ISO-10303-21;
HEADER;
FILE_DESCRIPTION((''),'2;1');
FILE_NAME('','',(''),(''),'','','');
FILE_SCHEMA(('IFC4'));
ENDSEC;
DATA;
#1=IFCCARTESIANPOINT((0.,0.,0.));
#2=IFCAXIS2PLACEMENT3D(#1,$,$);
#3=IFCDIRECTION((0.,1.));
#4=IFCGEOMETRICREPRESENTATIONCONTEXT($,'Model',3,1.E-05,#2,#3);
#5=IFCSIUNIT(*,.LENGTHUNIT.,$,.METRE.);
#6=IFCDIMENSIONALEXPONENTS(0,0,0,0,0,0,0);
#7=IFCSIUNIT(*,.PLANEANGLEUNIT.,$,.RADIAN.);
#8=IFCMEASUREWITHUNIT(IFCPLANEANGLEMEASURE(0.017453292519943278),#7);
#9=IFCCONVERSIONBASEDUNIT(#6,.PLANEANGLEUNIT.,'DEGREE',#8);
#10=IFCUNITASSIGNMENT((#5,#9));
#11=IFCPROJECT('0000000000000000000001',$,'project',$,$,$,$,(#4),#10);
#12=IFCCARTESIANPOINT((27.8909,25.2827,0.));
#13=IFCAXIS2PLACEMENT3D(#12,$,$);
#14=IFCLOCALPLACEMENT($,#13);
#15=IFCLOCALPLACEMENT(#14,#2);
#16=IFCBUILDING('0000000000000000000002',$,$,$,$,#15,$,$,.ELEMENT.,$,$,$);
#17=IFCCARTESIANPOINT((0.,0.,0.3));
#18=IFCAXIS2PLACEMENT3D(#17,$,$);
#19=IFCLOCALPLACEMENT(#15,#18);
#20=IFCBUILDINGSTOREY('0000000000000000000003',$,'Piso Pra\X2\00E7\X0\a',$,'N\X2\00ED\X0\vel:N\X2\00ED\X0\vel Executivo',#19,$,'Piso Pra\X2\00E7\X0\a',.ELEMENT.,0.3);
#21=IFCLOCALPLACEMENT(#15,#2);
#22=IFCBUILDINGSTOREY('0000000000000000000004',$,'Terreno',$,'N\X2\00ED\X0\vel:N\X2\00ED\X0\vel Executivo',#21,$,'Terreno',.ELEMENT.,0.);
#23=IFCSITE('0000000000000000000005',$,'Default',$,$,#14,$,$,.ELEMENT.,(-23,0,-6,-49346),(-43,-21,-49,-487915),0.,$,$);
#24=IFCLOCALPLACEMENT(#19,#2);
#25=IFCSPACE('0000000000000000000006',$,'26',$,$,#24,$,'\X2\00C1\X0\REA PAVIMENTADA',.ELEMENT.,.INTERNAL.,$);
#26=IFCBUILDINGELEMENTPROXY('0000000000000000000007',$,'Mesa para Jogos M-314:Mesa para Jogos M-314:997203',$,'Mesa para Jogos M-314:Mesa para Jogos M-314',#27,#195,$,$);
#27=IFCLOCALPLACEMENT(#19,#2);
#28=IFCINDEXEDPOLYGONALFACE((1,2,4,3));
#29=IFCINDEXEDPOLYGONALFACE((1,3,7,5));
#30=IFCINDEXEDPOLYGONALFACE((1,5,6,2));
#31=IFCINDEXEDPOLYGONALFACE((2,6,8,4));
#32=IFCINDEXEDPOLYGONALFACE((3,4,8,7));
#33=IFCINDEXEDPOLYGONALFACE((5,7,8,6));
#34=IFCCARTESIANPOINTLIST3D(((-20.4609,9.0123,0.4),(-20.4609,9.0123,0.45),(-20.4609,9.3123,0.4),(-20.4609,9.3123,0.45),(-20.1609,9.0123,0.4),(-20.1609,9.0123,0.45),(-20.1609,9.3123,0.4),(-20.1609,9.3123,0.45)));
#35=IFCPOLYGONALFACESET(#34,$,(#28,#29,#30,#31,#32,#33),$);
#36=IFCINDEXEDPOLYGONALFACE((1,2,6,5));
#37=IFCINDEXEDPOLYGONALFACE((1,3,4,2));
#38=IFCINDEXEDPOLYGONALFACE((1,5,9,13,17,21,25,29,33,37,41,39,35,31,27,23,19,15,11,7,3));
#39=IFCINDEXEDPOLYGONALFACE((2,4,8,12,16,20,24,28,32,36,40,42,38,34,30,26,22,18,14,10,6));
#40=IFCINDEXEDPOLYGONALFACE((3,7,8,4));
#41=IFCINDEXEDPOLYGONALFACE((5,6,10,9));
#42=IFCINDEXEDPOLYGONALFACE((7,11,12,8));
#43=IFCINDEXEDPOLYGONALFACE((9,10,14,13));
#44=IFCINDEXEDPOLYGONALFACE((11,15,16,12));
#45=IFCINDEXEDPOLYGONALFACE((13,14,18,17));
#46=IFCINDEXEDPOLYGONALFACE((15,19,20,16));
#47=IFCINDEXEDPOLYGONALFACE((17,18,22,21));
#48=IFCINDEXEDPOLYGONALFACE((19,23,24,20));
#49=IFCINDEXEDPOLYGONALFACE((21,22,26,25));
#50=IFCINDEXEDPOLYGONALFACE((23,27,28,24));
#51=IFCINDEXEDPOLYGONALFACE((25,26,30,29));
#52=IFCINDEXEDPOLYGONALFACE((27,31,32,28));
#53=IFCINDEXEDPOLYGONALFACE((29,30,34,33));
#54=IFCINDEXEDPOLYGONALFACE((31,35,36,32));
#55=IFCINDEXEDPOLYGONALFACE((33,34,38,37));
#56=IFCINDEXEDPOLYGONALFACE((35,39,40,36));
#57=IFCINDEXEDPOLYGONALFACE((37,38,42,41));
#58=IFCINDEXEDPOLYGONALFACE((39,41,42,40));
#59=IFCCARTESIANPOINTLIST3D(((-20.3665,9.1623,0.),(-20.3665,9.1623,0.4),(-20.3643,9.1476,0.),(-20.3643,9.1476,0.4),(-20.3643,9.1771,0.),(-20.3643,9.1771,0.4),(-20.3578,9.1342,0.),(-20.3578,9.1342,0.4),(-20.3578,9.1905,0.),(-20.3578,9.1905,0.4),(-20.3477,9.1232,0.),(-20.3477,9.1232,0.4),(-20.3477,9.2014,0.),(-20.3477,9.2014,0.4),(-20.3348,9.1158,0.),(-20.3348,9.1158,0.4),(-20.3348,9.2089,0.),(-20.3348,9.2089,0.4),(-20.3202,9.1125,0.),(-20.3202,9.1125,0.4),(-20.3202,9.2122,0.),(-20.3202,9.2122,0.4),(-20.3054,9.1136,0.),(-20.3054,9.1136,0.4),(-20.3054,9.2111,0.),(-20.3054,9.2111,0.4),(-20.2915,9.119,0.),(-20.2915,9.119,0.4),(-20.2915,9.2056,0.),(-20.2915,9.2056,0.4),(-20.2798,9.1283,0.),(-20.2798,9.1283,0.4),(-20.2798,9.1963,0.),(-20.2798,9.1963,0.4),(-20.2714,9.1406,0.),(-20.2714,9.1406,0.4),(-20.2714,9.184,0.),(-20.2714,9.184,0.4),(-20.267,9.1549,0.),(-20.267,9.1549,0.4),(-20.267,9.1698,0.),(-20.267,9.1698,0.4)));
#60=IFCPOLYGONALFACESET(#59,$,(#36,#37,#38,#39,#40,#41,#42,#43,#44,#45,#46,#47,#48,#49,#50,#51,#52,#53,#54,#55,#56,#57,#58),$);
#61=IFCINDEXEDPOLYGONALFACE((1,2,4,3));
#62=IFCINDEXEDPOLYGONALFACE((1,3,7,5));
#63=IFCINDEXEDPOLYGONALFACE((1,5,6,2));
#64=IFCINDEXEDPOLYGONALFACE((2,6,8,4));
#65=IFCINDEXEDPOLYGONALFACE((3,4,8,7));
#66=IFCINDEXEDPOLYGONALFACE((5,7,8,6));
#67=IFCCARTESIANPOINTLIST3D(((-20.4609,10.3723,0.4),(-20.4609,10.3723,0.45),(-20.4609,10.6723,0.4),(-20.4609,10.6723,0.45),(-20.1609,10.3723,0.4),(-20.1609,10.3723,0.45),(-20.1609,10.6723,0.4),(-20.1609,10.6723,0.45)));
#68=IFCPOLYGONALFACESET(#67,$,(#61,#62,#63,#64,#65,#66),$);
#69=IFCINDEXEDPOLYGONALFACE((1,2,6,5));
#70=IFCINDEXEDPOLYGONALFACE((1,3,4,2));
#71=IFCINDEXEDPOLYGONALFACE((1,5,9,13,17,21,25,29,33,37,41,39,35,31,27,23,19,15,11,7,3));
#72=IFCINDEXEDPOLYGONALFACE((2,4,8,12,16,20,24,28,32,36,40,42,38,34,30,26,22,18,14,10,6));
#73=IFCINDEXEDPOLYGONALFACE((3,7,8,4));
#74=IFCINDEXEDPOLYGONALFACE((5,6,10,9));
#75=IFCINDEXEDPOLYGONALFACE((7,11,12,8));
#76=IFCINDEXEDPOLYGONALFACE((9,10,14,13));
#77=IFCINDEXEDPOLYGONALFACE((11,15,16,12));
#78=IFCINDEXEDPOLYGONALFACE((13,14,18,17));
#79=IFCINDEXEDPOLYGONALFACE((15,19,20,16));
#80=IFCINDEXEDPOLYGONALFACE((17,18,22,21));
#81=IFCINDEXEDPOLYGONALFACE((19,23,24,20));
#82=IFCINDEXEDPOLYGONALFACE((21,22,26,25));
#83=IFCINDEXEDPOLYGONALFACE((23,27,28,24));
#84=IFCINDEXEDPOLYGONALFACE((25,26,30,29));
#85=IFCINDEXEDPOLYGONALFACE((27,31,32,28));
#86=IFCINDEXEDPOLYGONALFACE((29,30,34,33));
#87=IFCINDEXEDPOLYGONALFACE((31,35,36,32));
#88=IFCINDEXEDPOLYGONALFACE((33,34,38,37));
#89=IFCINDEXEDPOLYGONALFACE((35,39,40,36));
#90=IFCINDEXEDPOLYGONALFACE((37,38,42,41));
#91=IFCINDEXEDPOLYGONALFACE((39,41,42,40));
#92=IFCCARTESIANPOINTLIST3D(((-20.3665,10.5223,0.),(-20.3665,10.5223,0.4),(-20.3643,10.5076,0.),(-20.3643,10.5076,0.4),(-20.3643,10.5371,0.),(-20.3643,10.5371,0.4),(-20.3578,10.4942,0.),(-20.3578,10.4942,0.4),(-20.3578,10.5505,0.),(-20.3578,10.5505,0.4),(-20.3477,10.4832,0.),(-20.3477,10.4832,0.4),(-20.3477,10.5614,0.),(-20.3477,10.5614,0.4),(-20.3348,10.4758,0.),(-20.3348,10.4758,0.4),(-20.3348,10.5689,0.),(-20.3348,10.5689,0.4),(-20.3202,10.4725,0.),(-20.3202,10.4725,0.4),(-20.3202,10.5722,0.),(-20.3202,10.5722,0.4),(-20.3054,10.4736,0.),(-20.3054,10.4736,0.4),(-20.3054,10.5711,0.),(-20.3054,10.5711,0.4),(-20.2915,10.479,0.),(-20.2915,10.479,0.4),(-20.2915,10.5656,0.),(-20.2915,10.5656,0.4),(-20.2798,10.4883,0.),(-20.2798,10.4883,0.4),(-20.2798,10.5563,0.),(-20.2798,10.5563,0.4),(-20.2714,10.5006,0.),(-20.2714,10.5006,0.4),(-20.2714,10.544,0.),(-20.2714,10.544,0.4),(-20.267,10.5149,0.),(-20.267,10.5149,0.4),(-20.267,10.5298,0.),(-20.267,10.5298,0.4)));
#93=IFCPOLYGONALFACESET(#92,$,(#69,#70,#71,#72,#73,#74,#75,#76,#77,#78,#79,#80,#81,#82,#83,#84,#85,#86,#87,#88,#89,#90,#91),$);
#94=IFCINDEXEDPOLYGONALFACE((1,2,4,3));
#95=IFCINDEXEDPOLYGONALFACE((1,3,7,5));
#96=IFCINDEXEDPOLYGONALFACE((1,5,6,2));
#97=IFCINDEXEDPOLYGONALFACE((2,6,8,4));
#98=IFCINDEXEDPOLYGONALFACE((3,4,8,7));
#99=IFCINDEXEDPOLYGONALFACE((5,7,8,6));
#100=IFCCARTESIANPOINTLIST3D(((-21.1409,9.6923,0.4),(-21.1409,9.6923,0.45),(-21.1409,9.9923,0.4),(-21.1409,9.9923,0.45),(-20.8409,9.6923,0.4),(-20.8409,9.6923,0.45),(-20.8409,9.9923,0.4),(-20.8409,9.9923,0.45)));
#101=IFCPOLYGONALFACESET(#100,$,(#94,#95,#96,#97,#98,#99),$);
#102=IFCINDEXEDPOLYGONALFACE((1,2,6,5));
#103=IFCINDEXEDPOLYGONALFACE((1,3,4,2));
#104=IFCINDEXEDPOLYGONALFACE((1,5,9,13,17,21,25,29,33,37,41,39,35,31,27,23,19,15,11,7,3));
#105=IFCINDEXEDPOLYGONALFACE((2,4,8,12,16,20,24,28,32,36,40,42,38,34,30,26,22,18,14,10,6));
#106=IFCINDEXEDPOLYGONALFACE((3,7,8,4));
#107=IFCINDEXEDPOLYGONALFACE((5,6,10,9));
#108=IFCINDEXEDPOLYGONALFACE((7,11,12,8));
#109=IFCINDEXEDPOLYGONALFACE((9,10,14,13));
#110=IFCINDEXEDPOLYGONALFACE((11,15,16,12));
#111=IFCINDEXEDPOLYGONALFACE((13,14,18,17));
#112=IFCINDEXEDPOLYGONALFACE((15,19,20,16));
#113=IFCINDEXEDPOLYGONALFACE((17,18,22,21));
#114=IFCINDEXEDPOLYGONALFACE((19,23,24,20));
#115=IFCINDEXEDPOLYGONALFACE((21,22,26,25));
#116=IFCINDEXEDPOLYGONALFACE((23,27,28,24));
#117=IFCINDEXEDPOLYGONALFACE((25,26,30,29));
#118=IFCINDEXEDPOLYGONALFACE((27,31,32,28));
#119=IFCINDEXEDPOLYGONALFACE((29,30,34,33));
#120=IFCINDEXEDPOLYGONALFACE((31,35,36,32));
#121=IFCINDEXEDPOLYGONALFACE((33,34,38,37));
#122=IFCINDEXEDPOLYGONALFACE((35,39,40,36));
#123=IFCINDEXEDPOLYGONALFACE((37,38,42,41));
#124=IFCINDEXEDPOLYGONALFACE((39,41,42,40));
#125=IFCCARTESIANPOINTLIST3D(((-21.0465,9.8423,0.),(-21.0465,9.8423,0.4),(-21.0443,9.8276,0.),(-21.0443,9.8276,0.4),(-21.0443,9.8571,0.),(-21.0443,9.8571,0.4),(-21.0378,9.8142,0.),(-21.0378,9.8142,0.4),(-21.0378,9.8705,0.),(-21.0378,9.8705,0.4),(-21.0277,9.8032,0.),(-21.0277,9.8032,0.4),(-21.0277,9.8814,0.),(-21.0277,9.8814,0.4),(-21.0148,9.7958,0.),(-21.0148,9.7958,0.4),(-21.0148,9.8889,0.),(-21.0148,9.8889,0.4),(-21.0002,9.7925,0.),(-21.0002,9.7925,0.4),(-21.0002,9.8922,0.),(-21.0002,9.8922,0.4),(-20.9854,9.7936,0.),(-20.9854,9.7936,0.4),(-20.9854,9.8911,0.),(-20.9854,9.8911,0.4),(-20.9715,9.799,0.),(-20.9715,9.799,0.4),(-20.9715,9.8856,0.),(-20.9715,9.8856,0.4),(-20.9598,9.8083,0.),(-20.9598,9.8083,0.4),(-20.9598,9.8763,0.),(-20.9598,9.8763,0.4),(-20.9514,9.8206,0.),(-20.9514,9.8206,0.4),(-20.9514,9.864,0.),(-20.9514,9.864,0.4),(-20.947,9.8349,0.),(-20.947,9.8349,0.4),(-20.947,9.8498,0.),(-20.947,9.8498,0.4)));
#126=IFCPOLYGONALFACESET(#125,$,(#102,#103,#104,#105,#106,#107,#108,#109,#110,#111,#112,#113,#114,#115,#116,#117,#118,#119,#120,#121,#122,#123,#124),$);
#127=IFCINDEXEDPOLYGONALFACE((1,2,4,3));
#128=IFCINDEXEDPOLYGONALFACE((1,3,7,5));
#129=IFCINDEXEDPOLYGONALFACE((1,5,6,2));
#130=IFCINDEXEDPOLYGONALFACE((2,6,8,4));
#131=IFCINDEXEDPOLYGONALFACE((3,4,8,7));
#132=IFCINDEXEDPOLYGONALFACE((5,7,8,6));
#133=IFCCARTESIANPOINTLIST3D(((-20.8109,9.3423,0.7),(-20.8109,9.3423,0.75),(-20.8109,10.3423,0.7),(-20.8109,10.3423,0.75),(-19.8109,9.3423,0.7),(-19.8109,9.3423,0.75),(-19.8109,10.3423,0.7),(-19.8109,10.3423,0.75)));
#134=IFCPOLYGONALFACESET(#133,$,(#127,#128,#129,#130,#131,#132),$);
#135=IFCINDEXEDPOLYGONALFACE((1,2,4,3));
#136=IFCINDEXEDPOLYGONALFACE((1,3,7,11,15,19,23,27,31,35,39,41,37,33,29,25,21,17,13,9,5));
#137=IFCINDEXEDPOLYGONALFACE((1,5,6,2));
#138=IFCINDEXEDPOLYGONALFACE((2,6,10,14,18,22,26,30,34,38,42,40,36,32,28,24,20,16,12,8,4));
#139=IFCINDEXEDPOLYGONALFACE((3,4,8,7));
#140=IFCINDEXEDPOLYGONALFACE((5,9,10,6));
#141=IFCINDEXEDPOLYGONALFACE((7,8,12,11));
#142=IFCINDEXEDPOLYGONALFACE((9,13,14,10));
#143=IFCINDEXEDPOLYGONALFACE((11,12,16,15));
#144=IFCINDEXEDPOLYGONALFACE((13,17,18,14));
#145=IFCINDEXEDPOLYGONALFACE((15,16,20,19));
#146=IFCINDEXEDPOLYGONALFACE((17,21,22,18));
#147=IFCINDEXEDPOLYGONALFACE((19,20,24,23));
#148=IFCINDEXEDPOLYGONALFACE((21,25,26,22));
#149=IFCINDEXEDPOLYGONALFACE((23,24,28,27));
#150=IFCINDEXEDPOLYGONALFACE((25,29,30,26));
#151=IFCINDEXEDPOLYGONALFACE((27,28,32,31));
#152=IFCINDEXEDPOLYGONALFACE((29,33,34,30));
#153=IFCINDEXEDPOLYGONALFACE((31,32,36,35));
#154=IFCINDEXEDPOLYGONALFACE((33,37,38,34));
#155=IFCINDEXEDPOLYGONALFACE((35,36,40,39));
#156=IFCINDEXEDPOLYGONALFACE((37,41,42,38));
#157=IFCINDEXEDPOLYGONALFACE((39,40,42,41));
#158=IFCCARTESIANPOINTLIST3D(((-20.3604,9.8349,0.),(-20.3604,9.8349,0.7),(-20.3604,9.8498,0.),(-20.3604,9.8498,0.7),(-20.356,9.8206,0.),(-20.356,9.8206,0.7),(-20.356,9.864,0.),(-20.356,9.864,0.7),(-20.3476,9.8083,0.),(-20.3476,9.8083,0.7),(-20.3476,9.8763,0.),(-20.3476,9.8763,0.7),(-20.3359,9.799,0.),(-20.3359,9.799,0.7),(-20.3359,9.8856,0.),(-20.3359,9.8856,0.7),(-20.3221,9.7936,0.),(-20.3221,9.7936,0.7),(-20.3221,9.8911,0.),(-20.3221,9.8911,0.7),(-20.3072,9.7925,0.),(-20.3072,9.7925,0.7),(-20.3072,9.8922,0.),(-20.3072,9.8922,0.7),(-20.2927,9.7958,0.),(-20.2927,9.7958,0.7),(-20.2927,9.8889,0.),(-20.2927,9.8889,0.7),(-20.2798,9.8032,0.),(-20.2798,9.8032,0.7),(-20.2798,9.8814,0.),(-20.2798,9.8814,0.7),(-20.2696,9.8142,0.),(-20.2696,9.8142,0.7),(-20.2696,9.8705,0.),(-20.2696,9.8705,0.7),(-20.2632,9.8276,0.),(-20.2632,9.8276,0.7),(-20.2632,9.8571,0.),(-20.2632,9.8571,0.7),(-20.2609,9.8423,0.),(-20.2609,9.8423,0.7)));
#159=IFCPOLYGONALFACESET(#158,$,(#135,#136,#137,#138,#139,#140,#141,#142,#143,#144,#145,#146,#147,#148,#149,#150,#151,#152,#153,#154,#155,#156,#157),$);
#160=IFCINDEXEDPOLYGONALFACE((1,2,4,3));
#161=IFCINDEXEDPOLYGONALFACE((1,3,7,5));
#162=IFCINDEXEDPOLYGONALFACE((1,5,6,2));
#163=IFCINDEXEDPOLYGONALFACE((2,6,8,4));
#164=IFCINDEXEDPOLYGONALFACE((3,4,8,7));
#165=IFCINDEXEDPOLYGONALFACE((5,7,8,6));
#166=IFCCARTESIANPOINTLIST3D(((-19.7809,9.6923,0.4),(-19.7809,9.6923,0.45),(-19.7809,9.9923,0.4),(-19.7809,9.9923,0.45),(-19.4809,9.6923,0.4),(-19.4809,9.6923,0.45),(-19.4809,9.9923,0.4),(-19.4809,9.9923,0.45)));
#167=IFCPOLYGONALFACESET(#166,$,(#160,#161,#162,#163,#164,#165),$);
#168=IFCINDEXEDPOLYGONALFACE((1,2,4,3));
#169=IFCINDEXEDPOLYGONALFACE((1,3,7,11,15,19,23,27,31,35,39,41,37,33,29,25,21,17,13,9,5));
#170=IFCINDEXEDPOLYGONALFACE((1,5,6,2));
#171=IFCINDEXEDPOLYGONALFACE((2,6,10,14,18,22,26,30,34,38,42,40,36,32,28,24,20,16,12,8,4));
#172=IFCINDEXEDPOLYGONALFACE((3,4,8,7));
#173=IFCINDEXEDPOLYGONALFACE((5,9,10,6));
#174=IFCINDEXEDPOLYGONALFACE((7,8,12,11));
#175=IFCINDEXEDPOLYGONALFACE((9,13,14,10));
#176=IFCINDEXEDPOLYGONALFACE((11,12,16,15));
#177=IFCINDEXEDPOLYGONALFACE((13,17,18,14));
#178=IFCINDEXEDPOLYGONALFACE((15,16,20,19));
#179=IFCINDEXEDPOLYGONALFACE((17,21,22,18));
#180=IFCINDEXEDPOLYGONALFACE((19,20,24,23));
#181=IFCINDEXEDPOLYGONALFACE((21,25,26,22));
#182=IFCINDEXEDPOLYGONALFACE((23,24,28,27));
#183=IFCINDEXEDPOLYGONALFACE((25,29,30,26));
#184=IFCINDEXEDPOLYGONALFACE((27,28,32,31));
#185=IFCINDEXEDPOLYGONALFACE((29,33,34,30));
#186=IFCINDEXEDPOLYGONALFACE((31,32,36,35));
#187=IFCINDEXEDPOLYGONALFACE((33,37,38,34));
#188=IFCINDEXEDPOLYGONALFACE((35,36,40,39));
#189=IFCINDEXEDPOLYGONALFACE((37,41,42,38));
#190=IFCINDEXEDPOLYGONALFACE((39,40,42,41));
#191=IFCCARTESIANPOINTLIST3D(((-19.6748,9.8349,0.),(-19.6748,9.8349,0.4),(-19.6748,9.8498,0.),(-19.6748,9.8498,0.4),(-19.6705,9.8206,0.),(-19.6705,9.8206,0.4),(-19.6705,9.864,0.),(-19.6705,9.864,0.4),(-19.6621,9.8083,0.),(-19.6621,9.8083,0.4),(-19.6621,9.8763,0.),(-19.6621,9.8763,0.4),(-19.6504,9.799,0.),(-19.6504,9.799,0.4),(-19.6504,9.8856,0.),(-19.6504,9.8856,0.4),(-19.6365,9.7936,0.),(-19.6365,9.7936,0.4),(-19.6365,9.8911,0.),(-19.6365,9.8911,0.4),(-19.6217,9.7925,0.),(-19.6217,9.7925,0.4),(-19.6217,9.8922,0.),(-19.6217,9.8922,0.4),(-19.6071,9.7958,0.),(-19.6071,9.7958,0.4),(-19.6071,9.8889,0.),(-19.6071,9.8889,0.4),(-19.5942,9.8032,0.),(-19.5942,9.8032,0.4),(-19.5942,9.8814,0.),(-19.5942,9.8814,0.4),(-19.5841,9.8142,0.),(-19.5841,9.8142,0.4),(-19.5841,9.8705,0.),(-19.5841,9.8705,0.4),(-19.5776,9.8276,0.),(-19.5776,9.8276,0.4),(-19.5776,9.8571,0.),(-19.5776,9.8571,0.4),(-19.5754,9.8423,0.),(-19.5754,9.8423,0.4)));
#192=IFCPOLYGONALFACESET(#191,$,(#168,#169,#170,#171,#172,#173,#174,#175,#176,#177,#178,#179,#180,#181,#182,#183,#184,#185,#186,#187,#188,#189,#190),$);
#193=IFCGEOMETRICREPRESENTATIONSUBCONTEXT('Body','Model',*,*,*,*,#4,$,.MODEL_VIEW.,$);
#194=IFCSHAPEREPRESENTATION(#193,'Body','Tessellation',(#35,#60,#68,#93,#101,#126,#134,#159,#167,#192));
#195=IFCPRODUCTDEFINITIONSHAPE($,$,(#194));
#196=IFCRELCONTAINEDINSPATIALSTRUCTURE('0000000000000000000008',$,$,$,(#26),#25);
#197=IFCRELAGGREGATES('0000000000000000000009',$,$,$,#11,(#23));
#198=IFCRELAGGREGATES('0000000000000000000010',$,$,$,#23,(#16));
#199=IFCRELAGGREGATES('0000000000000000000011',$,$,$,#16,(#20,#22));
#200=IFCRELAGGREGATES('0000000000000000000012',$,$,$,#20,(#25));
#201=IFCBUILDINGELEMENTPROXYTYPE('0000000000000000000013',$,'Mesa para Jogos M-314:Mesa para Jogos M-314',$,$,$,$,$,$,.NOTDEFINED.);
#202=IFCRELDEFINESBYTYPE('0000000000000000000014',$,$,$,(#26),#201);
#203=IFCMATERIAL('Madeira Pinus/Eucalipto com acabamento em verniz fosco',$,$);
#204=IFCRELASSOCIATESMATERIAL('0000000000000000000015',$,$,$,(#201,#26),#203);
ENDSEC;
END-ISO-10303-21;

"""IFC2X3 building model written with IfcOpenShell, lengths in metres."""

from ifc_helpers import new_model, entity, si_unit, converted_unit, direction, frame, frame_2d, origin, place, context, subcontext, project, spatial, rectangle, circle, extrude, source, transform, mapped, material, type_object, type_shapes, element, save


model = new_model("IFC2X3")

# Units and contexts
model_context = context("Model", 3, precision=1e-05, world=origin(), true_north=direction((0.0, 1.0)))
body_context = subcontext(model_context, "Body", "Model", "MODEL_VIEW")
ifc_project = project(units=[si_unit("LENGTHUNIT", "METRE"), converted_unit("PLANEANGLEUNIT", "DEGREE", entity("IfcPlaneAngleMeasure", 0.017453292519943278), si_unit("PLANEANGLEUNIT", "RADIAN"), dimensions=[0, 0, 0, 0, 0, 0, 0])], contexts=[model_context])

# Site, building, storey
site_placement = place(None, frame((27.8909, 25.2827, 0.0)))
site = spatial("IfcSite", under=ifc_project, at=site_placement, Name="Default", CompositionType="ELEMENT", RefLatitude=(-23, 0, -6, -49346), RefLongitude=(-43, -21, -49, -487915), RefElevation=0.0)
building_placement = place(site_placement, origin())
building = spatial("IfcBuilding", under=site, at=building_placement, CompositionType="ELEMENT")
storey_1_placement = place(building_placement, frame((0.0, 0.0, 0.3)))
storey_1 = spatial("IfcBuildingStorey", under=building, at=storey_1_placement, Name="Piso Praça", ObjectType="Nível:Nível Executivo", LongName="Piso Praça", CompositionType="ELEMENT", Elevation=0.3)

# Shared definitions
ifc_material_1 = material(Name="Madeira Pinus/Eucalipto com acabamento em verniz fosco")

# Shared definitions
space_1_placement = place(storey_1_placement, origin())
space_1 = spatial("IfcSpace", under=storey_1, at=space_1_placement, Name="26", LongName="ÁREA PAVIMENTADA", CompositionType="ELEMENT", InteriorOrExteriorSpace="INTERNAL")

# Building element proxy
building_element_proxy_type_1 = type_object("IfcBuildingElementProxyType", Name="Mesa para Jogos M-314:Mesa para Jogos M-314", PredefinedType="NOTDEFINED", material=ifc_material_1)
shared_shape_1 = source(origin(), body_context, "Body", "SweptSolid", [
    extrude(rectangle(XDim=0.3, YDim=0.3, at=frame_2d((0.0, 0.0), x_axis=(1.0, 0.0))), frame((0.0, -0.68, 0.4)), (0.0, 0.0, 1.0), 0.05),
    extrude(circle(Radius=0.05, at=frame_2d((0.0, 0.0), x_axis=(1.0, 0.0))), frame((-0.0055, -0.68, 0.0), z_axis=(0.0, 0.0, 1.0), x_axis=(-1.0, 0.0, 0.0)), (0.0, 0.0, 1.0), 0.4),
    extrude(rectangle(XDim=0.3, YDim=0.3, at=frame_2d((0.0, 0.0), x_axis=(1.0, 0.0))), frame((0.0, 0.68, 0.4), z_axis=(0.0, 0.0, 1.0), x_axis=(0.0, -1.0, 0.0)), (0.0, 0.0, 1.0), 0.05),
    extrude(circle(Radius=0.05, at=frame_2d((0.0, 0.0), x_axis=(1.0, 0.0))), frame((-0.0055, 0.68, 0.0), z_axis=(0.0, 0.0, 1.0), x_axis=(-1.0, 0.0, 0.0)), (0.0, 0.0, 1.0), 0.4),
    extrude(rectangle(XDim=0.3, YDim=0.3, at=frame_2d((0.0, 0.0), x_axis=(1.0, 0.0))), frame((-0.68, 0.0, 0.4), z_axis=(0.0, 0.0, 1.0), x_axis=(0.0, -1.0, 0.0)), (0.0, 0.0, 1.0), 0.05),
    extrude(circle(Radius=0.05, at=frame_2d((0.0, 0.0), x_axis=(1.0, 0.0))), frame((-0.6855, 0.0, 0.0), z_axis=(0.0, 0.0, 1.0), x_axis=(-1.0, 0.0, 0.0)), (0.0, 0.0, 1.0), 0.4),
    extrude(rectangle(XDim=1.0, YDim=1.0, at=frame_2d((0.0, 0.0), x_axis=(1.0, 0.0))), frame((0.0, 0.0, 0.7), z_axis=(0.0, 0.0, 1.0), x_axis=(-1.0, 0.0, 0.0)), (0.0, 0.0, 1.0), 0.05),
    extrude(circle(Radius=0.05, at=frame_2d((0.0, 0.0), x_axis=(1.0, 0.0))), origin(), (0.0, 0.0, 1.0), 0.7),
    extrude(rectangle(XDim=0.3, YDim=0.3, at=frame_2d((0.0, 0.0), x_axis=(1.0, 0.0))), frame((0.68, 0.0, 0.4), z_axis=(0.0, 0.0, 1.0), x_axis=(-1.0, 0.0, 0.0)), (0.0, 0.0, 1.0), 0.05),
    extrude(circle(Radius=0.05, at=frame_2d((0.0, 0.0), x_axis=(1.0, 0.0))), frame((0.6855, 0.0, 0.0)), (0.0, 0.0, 1.0), 0.4),
])
type_shapes(building_element_proxy_type_1, [shared_shape_1])
for number, where, name in (
    (1, (-20.3109, 9.8423, 0.0), "Mesa para Jogos M-314:Mesa para Jogos M-314:997203"),
):
    element("IfcBuildingElementProxy", number, at=place(space_1_placement, frame(where)), inside=space_1, type_object=building_element_proxy_type_1, material=ifc_material_1, Name=name, ObjectType="Mesa para Jogos M-314:Mesa para Jogos M-314", context=body_context, shape_type="MappedRepresentation", body=[
        mapped(shared_shape_1, transform((0.0, 0.0, 0.0), scale=1.0)),
    ])

# Shared definitions
storey_2_placement = place(building_placement, origin())
storey_2 = spatial("IfcBuildingStorey", under=building, at=storey_2_placement, Name="Terreno", ObjectType="Nível:Nível Executivo", LongName="Terreno", CompositionType="ELEMENT", Elevation=0.0)

save(model, "model.ifc")
